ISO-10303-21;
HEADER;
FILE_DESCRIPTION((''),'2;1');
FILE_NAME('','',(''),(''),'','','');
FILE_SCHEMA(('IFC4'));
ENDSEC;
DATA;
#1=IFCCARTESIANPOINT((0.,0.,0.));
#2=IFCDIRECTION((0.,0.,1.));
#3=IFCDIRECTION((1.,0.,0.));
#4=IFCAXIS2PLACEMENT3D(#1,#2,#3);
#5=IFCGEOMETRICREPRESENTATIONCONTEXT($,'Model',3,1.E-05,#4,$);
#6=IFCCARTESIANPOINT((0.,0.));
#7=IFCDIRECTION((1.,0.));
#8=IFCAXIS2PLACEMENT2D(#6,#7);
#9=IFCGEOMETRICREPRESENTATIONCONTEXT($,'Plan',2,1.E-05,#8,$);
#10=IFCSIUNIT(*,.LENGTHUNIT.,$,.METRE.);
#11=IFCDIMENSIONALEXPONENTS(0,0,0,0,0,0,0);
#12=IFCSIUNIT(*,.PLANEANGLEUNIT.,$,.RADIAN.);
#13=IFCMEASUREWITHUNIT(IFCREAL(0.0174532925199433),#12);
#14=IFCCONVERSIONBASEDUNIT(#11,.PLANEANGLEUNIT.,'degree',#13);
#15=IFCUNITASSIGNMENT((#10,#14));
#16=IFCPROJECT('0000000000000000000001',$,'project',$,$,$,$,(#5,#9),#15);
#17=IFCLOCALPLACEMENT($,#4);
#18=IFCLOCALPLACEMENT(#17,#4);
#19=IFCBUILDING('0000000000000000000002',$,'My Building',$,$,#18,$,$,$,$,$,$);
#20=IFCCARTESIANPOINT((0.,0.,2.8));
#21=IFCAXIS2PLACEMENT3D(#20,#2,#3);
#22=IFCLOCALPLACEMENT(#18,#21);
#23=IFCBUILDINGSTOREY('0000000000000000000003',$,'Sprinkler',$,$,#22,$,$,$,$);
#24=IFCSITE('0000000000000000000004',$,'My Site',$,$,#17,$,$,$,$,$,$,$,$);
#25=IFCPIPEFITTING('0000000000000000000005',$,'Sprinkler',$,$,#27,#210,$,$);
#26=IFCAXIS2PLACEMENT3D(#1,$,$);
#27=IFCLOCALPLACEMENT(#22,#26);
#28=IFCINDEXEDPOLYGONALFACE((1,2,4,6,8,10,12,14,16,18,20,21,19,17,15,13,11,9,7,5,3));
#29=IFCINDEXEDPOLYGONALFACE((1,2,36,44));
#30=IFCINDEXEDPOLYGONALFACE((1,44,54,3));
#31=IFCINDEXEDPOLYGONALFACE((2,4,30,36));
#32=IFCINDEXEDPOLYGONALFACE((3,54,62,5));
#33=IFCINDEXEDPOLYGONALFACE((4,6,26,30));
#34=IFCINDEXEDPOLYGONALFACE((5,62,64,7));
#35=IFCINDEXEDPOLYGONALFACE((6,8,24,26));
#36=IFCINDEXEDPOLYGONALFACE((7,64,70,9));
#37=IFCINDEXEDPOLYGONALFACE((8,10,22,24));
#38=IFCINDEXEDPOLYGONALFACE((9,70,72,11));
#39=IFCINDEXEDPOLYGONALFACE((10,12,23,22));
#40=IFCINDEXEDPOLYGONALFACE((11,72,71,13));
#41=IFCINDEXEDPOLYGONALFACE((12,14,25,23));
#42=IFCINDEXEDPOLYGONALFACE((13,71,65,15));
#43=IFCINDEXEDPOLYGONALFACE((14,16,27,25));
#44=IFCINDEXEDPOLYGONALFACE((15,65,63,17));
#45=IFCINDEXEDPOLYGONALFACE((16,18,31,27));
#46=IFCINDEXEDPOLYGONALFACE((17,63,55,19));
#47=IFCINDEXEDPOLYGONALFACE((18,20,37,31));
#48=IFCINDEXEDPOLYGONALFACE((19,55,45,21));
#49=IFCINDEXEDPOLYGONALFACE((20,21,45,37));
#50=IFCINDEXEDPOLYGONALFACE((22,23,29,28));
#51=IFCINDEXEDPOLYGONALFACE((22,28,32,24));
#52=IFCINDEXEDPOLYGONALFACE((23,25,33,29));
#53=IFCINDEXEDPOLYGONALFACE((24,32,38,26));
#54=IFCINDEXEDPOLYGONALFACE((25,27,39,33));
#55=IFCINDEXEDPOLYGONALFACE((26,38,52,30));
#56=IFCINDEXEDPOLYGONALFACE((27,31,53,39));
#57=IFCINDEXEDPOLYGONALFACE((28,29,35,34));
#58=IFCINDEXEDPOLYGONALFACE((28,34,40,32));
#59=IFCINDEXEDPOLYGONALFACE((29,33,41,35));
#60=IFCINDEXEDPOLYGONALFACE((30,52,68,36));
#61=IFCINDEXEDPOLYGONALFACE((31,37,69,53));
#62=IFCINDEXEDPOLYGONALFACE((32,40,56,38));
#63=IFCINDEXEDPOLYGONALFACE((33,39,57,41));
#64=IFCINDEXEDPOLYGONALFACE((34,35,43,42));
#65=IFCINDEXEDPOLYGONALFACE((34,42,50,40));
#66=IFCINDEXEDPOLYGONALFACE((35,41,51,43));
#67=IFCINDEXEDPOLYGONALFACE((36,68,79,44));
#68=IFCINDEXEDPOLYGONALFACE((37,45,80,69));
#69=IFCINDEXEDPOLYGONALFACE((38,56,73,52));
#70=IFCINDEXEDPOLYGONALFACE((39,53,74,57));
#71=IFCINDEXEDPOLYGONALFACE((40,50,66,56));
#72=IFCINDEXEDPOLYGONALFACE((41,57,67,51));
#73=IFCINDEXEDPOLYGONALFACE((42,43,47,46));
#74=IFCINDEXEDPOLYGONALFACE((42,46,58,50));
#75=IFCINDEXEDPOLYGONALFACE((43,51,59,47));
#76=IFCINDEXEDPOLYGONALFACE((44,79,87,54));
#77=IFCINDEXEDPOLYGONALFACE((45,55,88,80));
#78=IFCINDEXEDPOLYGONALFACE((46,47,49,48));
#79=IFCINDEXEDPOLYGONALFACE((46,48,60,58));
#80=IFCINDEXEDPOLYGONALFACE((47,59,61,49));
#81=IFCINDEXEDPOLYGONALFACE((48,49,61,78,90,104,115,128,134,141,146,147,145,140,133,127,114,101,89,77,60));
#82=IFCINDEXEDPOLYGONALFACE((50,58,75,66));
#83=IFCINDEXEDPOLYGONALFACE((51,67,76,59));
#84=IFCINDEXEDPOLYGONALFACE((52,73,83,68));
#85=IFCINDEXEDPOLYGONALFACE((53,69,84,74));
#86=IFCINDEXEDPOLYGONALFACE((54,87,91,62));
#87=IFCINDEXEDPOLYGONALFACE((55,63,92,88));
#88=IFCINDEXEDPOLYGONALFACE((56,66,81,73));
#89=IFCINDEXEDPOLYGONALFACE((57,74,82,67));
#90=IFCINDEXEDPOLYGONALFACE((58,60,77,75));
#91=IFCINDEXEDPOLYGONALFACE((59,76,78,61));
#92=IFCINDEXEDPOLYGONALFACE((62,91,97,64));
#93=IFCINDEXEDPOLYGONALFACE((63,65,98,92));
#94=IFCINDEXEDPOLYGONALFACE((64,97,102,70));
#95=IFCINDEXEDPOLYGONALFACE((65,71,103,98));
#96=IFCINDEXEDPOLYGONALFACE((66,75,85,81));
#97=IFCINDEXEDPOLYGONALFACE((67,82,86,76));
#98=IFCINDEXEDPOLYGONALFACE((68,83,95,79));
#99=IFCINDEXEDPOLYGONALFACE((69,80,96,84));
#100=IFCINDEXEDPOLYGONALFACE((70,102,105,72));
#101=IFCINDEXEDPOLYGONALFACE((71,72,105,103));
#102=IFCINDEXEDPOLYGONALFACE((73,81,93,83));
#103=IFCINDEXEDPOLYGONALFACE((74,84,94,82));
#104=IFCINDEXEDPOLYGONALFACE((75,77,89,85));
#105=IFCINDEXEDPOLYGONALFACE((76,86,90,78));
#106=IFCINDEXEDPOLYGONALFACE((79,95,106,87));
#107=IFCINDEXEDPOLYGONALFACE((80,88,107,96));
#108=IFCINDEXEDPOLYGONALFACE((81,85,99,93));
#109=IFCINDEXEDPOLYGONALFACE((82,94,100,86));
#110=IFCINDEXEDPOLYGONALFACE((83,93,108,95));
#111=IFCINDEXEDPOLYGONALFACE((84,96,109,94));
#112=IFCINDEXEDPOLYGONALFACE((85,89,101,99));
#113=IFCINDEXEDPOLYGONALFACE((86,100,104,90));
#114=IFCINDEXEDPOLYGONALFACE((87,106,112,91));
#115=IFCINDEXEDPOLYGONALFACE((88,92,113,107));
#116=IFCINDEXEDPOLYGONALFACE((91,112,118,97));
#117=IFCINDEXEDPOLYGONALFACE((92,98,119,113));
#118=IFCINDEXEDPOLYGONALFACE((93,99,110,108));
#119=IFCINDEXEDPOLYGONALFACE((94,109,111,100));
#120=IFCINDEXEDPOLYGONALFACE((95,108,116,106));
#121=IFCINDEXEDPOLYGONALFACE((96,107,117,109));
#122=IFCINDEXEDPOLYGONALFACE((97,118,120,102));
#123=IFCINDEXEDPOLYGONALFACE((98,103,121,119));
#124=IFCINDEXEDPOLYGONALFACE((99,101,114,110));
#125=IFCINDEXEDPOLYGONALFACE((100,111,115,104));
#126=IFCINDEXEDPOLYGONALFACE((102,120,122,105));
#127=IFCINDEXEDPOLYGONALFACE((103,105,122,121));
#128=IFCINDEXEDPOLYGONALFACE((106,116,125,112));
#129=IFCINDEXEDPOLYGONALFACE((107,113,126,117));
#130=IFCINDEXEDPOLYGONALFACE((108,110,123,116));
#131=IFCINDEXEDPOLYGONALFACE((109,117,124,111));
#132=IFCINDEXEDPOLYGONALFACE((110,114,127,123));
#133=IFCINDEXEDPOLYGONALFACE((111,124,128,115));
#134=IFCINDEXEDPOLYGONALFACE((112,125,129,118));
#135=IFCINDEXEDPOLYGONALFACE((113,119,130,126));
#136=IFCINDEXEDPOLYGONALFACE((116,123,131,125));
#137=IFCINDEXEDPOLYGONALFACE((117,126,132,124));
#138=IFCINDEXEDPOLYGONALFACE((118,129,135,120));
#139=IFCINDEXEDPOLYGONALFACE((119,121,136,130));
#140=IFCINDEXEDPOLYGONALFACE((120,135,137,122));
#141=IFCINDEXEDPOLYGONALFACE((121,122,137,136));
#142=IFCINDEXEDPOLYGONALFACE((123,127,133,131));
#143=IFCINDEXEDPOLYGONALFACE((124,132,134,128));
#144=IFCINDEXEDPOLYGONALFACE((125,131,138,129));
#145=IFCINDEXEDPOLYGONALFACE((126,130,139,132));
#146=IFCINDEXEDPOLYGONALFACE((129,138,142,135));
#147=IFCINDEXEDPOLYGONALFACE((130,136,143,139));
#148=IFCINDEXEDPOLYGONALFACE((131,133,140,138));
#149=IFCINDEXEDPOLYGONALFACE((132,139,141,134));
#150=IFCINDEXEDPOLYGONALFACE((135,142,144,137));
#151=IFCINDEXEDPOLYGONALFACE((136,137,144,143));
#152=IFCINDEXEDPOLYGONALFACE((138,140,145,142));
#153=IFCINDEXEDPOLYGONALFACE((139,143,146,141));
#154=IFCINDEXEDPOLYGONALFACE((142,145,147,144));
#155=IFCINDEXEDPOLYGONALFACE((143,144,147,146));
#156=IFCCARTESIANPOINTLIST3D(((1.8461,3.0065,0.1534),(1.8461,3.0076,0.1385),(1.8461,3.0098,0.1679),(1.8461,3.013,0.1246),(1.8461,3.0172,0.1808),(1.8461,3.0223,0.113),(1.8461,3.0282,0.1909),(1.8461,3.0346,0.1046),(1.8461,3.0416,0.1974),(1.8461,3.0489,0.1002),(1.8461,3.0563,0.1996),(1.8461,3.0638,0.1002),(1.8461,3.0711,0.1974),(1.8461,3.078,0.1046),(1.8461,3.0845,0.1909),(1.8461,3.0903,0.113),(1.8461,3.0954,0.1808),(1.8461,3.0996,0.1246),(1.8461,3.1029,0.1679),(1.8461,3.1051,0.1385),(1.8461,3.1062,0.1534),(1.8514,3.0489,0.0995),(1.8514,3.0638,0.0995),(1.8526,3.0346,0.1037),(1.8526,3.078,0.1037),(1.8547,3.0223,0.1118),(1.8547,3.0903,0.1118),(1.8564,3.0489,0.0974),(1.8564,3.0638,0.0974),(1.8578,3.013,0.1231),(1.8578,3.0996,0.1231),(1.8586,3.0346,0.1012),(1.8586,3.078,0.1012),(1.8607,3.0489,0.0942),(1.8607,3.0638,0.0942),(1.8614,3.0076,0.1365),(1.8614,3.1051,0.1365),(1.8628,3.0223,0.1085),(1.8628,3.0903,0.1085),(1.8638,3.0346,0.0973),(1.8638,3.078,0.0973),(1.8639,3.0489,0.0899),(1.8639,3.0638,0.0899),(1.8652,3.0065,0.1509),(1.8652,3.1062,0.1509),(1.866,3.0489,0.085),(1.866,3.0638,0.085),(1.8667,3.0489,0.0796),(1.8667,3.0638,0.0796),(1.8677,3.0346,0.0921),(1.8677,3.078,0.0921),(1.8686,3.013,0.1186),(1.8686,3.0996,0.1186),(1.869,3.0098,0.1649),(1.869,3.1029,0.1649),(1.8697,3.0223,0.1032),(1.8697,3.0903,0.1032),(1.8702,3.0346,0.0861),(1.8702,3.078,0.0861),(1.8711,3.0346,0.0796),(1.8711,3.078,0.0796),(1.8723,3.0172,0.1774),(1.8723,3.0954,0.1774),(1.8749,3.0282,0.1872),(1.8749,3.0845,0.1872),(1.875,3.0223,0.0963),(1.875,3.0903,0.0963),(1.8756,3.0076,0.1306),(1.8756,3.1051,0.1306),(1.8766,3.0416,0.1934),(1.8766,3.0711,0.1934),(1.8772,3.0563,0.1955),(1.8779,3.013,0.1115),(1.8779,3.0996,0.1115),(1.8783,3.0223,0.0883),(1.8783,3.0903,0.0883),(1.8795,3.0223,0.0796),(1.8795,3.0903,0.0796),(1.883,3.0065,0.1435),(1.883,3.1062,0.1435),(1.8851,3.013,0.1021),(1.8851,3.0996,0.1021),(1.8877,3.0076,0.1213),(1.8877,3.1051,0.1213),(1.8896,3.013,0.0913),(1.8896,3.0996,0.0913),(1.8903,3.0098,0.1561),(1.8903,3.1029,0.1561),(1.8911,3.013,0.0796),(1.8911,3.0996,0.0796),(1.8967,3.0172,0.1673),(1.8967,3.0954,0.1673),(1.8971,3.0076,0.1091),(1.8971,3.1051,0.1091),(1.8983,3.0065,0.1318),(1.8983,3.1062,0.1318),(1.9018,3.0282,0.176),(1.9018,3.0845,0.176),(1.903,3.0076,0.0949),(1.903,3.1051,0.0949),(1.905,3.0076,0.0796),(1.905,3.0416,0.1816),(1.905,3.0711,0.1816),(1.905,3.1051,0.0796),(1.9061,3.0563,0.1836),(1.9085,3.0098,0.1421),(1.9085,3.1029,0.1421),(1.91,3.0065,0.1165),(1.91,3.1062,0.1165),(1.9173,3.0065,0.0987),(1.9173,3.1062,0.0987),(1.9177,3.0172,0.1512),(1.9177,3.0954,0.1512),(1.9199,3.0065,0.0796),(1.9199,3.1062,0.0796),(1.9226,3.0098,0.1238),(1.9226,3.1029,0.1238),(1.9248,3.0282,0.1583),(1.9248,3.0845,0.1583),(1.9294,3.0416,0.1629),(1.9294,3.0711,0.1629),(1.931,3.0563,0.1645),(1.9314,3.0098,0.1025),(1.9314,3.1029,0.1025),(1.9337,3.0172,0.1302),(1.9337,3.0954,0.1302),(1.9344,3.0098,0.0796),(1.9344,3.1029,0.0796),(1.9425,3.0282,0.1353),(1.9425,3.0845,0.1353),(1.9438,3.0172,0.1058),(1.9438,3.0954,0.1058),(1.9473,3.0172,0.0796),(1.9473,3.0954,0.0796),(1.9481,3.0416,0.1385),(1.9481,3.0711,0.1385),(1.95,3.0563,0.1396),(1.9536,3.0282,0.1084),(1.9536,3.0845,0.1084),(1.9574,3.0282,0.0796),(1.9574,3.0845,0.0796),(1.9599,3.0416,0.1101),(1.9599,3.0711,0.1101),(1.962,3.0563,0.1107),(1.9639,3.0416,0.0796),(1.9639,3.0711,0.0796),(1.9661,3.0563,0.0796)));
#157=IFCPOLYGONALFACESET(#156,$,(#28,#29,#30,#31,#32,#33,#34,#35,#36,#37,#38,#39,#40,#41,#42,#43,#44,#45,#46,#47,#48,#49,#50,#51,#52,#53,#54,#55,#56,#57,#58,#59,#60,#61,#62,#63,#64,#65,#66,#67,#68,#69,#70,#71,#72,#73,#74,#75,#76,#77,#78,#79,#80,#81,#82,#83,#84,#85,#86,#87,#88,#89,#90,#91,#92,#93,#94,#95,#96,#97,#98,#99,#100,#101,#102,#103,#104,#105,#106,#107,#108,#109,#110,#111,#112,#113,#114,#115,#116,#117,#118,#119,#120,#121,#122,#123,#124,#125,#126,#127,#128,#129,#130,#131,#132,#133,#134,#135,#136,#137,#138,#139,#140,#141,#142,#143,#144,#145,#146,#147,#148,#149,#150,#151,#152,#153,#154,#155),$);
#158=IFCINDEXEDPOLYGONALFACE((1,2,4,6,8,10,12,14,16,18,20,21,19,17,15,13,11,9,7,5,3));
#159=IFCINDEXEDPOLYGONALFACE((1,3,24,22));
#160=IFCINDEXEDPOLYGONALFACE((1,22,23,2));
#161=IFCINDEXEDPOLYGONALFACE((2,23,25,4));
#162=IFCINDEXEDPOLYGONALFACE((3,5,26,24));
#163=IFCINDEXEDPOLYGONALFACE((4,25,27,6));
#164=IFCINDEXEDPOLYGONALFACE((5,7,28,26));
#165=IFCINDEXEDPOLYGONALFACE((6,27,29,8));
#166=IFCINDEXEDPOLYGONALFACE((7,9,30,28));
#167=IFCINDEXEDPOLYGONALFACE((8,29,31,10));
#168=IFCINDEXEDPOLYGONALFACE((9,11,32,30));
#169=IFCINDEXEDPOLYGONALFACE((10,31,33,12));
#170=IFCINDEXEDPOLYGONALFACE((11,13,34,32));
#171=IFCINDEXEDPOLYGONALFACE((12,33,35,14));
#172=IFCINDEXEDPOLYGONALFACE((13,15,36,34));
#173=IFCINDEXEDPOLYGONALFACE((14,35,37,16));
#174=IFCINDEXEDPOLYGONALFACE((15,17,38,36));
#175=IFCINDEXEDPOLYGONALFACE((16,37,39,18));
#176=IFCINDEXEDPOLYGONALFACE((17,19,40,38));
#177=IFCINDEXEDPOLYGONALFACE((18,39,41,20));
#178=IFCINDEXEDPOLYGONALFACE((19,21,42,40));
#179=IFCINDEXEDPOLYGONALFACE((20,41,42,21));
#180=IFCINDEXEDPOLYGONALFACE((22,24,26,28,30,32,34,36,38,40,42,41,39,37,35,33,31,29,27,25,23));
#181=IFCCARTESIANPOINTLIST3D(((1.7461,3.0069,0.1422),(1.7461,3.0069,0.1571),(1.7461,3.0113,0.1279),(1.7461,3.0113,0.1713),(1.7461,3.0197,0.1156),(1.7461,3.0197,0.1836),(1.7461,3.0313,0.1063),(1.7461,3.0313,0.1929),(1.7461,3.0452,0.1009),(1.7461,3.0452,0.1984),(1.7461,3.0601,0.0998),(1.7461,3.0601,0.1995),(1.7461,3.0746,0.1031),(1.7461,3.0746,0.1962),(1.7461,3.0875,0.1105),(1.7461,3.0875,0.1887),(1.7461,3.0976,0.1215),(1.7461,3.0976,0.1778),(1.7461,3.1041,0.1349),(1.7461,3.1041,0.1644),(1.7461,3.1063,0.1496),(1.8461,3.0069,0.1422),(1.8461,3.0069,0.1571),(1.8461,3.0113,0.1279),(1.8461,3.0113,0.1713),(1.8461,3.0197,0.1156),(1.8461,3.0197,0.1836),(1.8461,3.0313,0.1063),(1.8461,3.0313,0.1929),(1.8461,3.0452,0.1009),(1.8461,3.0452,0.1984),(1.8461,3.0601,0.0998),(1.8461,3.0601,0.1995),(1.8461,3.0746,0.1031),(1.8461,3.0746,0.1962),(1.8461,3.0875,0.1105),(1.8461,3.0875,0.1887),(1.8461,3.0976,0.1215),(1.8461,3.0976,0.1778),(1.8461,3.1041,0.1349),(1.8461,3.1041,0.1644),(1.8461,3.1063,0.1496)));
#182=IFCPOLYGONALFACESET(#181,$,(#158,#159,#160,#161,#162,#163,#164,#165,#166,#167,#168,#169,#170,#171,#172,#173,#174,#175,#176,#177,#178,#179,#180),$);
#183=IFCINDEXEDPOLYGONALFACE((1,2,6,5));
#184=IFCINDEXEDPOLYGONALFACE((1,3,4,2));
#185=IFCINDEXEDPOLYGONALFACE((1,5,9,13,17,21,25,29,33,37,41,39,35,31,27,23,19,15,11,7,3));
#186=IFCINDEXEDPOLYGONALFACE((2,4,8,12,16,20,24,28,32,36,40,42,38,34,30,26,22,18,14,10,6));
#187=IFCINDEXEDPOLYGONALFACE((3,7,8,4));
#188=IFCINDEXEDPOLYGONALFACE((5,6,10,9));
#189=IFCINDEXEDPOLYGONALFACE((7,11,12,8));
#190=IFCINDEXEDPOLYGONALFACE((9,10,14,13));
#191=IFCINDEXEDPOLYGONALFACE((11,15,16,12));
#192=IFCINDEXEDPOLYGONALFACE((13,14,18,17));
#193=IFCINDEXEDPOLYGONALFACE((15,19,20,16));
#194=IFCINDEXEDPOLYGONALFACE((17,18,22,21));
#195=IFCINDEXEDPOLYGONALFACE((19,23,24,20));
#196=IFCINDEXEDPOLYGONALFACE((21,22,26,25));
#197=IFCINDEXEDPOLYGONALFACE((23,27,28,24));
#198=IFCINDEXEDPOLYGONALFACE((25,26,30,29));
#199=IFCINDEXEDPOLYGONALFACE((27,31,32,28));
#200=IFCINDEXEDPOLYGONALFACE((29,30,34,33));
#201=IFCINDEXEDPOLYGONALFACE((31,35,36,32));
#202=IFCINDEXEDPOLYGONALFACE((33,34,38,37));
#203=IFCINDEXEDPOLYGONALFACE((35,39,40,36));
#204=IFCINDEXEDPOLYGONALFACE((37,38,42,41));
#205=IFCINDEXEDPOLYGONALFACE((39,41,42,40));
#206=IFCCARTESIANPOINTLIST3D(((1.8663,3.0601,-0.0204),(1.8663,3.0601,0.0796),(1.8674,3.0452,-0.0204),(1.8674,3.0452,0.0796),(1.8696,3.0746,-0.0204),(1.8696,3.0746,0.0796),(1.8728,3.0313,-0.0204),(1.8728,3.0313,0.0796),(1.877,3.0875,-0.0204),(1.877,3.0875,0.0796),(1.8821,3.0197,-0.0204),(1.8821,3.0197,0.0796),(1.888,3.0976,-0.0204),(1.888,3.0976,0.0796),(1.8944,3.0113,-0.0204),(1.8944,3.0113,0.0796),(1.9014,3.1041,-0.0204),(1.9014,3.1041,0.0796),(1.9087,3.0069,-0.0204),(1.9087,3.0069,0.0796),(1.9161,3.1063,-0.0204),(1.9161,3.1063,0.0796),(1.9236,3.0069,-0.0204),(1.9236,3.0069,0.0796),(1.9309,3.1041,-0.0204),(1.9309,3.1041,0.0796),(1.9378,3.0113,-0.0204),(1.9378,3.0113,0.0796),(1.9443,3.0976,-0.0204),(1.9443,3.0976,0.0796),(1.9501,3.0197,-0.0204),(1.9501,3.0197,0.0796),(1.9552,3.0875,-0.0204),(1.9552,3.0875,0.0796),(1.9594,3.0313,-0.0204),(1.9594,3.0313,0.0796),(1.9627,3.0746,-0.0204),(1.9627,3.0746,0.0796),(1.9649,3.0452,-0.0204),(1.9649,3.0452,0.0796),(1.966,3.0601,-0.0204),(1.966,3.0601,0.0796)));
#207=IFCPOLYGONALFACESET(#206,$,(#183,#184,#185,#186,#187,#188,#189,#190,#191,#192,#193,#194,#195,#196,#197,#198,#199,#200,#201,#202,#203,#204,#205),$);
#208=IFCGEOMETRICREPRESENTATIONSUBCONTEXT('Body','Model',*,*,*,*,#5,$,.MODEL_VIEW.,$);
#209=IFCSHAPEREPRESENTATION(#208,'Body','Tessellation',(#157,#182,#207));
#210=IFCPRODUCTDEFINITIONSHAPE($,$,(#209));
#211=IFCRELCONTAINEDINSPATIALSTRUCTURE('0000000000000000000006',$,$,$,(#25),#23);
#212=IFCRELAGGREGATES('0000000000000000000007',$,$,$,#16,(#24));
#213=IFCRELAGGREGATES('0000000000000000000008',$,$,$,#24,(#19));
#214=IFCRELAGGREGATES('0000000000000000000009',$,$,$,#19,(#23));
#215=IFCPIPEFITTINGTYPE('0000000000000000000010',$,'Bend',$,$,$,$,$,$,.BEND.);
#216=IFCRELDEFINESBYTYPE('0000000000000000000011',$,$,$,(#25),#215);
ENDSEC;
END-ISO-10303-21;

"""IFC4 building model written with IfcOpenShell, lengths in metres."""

from ifc_helpers import new_model, entity, si_unit, converted_unit, frame, origin_with_axes, origin_2d_with_axis, place, context, subcontext, project, spatial, circle, extrude, source, transform, mapped, type_object, type_shapes, element, save


model = new_model("IFC4")

# Units and contexts
model_context = context("Model", 3, precision=1e-05, world=origin_with_axes())
plan_context = context("Plan", 2, precision=1e-05, world=origin_2d_with_axis())
body_context = subcontext(model_context, "Body", "Model", "MODEL_VIEW")
ifc_project = project(units=[si_unit("LENGTHUNIT", "METRE"), converted_unit("PLANEANGLEUNIT", "degree", entity("IfcReal", 0.0174532925199433), si_unit("PLANEANGLEUNIT", "RADIAN"), dimensions=[0, 0, 0, 0, 0, 0, 0])], contexts=[model_context, plan_context])

# Site, building, storey
site_placement = place(None, origin_with_axes())
site = spatial("IfcSite", under=ifc_project, at=site_placement, Name="My Site")
building_placement = place(site_placement, origin_with_axes())
building = spatial("IfcBuilding", under=site, at=building_placement, Name="My Building")
storey_placement = place(building_placement, frame((0.0, 0.0, 2.8), z_axis=(0.0, 0.0, 1.0), x_axis=(1.0, 0.0, 0.0)))
storey = spatial("IfcBuildingStorey", under=building, at=storey_placement, Name="Sprinkler")

# Pipe fitting
pipe_fitting_type_1 = type_object("IfcPipeFittingType", Name="Bend", PredefinedType="BEND")
shared_shape_1 = source(origin_with_axes(), body_context, "Body", "SolidModel", [
    entity("IfcSweptDiskSolid", entity("IfcIndexedPolyCurve", entity("IfcCartesianPointList3D", [[0.0, 0.0, 0.1], [0.0, -0.0205, 0.1495], [0.0, -0.07, 0.17]]), [entity("IfcArcIndex", [1, 2, 3])]), 0.05),
    extrude(circle(Radius=0.05), origin_with_axes(), (0.0, 0.0, 1.0), 0.1),
    extrude(circle(Radius=0.05), frame((0.0, -0.07, 0.17), z_axis=(0.0, -1.0, 0.0), x_axis=(1.0, 0.0, 0.0)), (0.0, 0.0, 1.0), 0.1),
])
type_shapes(pipe_fitting_type_1, [shared_shape_1])
for number, where, z_axis, x_axis, name in (
    (1, (1.7461, 3.0563, 0.1496), (1.0, 0.0, 0.0), (0.0, 1.0, 0.0), "Sprinkler"),
):
    element("IfcPipeFitting", number, at=place(storey_placement, frame(where, z_axis=z_axis, x_axis=x_axis)), inside=storey, type_object=pipe_fitting_type_1, Name=name, context=body_context, shape_type="MappedRepresentation", body=[
        mapped(shared_shape_1, transform((0.0, 0.0, 0.0), x_axis=(1.0, 0.0, 0.0), y_axis=(0.0, 1.0, 0.0), z_axis=(0.0, 0.0, 1.0), scale=1.0)),
    ])

save(model, "model.ifc")
